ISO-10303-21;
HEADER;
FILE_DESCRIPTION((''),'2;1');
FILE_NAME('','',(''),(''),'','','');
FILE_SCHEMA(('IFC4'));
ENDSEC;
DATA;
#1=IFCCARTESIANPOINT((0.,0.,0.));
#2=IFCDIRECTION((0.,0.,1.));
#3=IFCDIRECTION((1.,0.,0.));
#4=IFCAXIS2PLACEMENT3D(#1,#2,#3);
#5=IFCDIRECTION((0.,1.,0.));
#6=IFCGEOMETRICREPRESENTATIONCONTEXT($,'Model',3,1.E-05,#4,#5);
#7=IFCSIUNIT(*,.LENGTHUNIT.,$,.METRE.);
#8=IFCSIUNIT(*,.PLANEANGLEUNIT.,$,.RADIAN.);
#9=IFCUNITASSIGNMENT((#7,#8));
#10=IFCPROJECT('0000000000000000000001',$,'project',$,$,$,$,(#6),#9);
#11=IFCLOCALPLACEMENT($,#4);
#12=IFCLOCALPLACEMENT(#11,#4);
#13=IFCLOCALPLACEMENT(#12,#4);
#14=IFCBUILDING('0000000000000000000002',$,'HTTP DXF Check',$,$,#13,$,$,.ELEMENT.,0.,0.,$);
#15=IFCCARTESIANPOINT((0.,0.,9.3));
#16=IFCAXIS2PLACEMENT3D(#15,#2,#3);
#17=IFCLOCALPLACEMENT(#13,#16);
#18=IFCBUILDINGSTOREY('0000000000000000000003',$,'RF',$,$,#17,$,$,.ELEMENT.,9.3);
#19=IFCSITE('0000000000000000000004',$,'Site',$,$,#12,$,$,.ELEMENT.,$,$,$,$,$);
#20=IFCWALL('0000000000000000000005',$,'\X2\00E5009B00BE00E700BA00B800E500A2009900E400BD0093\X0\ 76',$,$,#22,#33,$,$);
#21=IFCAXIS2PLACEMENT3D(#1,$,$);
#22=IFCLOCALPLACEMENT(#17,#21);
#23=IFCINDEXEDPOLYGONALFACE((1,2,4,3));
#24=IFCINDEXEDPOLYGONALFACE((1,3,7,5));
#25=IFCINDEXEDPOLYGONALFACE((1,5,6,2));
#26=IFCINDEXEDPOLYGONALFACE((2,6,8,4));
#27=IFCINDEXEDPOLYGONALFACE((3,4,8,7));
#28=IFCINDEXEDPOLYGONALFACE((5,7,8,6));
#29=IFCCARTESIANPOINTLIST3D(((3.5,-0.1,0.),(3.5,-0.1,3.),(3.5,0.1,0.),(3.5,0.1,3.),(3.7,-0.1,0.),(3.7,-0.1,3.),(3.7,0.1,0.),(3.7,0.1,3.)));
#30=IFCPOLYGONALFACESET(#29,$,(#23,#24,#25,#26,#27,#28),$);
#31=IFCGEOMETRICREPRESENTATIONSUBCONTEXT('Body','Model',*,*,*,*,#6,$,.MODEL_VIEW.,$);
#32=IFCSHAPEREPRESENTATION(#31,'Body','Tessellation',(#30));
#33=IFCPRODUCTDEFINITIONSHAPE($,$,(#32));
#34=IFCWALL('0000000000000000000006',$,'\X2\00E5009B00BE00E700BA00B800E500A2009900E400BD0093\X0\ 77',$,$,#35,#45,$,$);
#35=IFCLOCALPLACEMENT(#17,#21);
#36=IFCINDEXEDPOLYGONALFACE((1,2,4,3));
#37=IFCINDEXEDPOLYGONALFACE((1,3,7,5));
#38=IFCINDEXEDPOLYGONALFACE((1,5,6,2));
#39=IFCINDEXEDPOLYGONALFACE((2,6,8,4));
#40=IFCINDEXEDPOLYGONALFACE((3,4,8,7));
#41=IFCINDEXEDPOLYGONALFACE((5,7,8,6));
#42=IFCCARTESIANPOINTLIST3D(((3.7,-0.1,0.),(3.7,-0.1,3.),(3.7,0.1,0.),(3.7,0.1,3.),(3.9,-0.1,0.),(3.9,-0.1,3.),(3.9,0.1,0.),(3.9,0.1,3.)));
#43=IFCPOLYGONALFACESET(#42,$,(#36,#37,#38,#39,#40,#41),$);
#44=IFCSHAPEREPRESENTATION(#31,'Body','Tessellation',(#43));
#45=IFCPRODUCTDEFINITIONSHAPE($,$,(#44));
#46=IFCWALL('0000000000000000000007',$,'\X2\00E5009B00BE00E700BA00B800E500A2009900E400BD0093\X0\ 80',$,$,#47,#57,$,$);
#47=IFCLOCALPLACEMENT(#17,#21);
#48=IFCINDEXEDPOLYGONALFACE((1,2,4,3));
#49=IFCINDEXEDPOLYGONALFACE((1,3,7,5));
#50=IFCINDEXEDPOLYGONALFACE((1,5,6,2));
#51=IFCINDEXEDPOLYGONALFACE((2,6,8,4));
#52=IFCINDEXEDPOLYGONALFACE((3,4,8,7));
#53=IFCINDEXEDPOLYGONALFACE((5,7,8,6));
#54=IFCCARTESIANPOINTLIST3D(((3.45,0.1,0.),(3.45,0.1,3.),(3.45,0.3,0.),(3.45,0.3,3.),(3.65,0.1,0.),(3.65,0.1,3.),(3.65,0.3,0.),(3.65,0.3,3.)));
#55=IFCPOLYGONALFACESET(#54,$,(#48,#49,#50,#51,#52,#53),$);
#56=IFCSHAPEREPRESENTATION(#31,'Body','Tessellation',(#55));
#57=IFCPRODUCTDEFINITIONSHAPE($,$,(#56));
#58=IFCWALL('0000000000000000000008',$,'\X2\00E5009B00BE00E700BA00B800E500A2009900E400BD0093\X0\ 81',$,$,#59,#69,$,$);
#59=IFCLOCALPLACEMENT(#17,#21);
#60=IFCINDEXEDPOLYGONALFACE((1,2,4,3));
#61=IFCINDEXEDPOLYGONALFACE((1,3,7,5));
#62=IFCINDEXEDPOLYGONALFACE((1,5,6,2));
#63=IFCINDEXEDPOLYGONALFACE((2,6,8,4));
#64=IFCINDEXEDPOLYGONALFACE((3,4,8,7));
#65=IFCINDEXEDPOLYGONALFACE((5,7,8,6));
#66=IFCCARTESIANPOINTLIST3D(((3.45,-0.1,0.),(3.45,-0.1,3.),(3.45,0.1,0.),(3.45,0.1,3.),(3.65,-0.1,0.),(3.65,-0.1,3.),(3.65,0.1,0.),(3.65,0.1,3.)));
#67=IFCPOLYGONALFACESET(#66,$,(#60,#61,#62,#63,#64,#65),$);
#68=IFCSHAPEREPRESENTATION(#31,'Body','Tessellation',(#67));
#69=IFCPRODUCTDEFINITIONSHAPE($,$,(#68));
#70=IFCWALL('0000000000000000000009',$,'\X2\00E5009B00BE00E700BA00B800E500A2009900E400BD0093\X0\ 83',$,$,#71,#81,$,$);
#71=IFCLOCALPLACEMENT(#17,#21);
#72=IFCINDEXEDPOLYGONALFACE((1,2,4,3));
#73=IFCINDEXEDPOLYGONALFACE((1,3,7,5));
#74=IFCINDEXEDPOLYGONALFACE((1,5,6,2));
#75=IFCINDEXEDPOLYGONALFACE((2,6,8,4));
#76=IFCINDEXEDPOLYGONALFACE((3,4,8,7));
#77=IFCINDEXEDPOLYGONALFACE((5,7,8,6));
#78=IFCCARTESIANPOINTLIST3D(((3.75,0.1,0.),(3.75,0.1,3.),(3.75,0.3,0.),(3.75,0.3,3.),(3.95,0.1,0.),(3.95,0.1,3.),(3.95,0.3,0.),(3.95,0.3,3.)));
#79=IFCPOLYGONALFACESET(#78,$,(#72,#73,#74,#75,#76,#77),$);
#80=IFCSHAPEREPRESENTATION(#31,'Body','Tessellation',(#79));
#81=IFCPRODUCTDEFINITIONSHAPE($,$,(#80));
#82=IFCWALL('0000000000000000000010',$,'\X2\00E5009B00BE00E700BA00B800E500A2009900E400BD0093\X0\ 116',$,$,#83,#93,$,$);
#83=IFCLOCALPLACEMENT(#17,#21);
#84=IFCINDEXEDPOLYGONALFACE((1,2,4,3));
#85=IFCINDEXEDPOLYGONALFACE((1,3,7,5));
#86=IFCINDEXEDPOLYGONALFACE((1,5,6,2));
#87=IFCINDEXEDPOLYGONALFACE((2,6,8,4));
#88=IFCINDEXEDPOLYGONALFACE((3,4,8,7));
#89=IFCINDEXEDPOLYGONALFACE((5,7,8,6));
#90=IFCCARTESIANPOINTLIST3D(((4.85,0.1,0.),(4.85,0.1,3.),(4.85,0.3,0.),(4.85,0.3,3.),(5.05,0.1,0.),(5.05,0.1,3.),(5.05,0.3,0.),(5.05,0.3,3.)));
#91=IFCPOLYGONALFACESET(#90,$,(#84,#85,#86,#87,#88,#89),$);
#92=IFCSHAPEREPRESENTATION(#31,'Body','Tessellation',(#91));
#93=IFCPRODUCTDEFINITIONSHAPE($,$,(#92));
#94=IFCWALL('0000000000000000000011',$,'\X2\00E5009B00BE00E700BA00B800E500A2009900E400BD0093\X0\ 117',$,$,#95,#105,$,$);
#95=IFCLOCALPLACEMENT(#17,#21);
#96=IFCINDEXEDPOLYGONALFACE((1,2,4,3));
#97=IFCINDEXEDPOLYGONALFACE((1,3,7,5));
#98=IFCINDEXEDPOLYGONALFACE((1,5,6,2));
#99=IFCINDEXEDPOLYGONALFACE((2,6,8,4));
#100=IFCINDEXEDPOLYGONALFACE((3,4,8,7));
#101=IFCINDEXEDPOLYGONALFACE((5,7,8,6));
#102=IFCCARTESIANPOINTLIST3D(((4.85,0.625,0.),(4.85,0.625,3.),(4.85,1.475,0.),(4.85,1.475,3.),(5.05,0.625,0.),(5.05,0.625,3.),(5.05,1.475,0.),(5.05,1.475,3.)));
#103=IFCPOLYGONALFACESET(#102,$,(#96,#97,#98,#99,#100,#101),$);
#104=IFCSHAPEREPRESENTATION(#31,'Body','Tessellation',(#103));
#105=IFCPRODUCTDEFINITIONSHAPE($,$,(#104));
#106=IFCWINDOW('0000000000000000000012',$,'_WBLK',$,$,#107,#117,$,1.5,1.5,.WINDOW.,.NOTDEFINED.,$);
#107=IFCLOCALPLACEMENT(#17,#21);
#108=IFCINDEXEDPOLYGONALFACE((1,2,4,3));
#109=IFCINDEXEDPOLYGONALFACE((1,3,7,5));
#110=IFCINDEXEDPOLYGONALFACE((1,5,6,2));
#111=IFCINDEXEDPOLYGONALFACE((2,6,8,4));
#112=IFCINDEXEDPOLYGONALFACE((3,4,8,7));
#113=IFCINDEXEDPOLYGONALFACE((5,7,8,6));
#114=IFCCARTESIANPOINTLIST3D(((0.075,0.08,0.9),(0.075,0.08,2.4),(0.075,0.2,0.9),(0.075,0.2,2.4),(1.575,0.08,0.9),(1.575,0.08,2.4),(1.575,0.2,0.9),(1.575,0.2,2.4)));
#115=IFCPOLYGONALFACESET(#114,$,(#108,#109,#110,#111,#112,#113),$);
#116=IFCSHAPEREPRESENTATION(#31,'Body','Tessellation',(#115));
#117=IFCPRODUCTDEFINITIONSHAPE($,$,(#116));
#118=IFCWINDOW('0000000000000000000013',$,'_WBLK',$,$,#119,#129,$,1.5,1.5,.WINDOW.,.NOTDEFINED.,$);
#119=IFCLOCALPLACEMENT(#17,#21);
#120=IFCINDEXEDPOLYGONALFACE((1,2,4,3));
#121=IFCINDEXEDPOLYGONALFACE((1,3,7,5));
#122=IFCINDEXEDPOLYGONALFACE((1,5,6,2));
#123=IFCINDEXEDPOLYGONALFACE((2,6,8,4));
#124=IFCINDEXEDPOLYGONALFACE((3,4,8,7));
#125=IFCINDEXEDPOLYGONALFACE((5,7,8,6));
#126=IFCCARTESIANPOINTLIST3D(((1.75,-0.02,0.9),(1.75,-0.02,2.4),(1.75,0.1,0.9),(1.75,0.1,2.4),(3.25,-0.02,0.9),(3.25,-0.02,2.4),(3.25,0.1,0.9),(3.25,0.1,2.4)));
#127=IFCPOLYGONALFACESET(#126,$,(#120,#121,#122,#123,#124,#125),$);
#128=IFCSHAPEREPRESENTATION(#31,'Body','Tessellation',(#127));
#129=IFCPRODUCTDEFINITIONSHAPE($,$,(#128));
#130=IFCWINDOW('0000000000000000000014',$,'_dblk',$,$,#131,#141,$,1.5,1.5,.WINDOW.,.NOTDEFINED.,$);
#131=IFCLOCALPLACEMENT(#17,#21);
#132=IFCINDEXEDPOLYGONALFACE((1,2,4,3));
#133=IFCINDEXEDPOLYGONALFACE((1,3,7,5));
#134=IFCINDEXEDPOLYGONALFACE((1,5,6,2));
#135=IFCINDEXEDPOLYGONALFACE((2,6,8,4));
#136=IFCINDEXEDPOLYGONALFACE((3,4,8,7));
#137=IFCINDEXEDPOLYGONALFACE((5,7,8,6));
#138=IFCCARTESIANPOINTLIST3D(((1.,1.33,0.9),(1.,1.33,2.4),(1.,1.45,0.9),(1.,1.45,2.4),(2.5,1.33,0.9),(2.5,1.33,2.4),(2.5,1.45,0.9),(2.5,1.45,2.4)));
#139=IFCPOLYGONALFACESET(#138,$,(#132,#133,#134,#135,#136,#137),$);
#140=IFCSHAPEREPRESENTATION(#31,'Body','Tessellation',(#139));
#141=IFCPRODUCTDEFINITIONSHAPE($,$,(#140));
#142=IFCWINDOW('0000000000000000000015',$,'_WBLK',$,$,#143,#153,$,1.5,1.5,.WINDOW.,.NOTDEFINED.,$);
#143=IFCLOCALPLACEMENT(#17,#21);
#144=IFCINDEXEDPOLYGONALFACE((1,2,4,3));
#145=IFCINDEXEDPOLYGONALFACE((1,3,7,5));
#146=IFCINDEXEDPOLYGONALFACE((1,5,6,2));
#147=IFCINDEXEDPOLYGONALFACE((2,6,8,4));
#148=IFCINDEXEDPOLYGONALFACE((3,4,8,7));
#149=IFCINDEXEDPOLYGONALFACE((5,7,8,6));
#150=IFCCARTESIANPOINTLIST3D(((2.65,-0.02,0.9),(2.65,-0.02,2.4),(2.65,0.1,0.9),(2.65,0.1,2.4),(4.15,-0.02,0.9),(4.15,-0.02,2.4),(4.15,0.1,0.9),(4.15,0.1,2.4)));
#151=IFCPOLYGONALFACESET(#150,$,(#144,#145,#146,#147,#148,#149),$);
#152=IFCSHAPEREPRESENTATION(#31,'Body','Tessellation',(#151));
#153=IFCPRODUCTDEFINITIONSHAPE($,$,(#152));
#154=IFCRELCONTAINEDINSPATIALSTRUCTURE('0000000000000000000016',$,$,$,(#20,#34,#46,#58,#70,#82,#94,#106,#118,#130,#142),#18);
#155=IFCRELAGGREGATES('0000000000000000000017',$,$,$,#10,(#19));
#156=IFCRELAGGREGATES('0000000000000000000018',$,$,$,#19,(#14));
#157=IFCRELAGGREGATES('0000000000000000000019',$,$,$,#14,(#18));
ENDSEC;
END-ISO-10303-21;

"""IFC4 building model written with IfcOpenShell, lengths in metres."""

from ifc_helpers import new_model, si_unit, direction, frame, frame_2d, origin_with_axes, place, context, subcontext, project, spatial, rectangle, extrude, element, save


model = new_model("IFC4")

# Units and contexts
model_context = context("Model", 3, precision=1e-05, world=origin_with_axes(), true_north=direction((0.0, 1.0, 0.0)))
body_context = subcontext(model_context, "Body", "Model", "MODEL_VIEW")
ifc_project = project(units=[si_unit("LENGTHUNIT", "METRE"), si_unit("PLANEANGLEUNIT", "RADIAN")], contexts=[model_context])

# Site, building, storey
placement = place(None, origin_with_axes())
site_placement = place(placement, origin_with_axes())
site = spatial("IfcSite", under=ifc_project, at=site_placement, Name="Site", CompositionType="ELEMENT")
building_placement = place(site_placement, origin_with_axes())
building = spatial("IfcBuilding", under=site, at=building_placement, Name="HTTP DXF Check", CompositionType="ELEMENT", ElevationOfRefHeight=0.0, ElevationOfTerrain=0.0)
storey_placement = place(building_placement, frame((0.0, 0.0, 9.3), z_axis=(0.0, 0.0, 1.0), x_axis=(1.0, 0.0, 0.0)))
storey = spatial("IfcBuildingStorey", under=building, at=storey_placement, Name="RF", CompositionType="ELEMENT", Elevation=9.3)

# Walls
for number, where, z_axis, x_axis, name in (
    (1, (3.6, 0.0, 0.0), (0.0, 0.0, 1.0), (1.0, 0.0, 0.0), "å\u009b¾çº¸å¢\u0099ä½\u0093 76"),
    (2, (3.8, 0.0, 0.0), (0.0, 0.0, 1.0), (1.0, 0.0, 0.0), "å\u009b¾çº¸å¢\u0099ä½\u0093 77"),
    (3, (3.55, 0.2, 0.0), (0.0, 0.0, 1.0), (1.0, 0.0, 0.0), "å\u009b¾çº¸å¢\u0099ä½\u0093 80"),
    (4, (3.55, 0.0, 0.0), (0.0, 0.0, 1.0), (1.0, 0.0, 0.0), "å\u009b¾çº¸å¢\u0099ä½\u0093 81"),
    (5, (3.85, 0.2, 0.0), (0.0, 0.0, 1.0), (-1.0, 0.0, 0.0), "å\u009b¾çº¸å¢\u0099ä½\u0093 83"),
    (6, (4.95, 0.2, 0.0), (0.0, 0.0, 1.0), (0.0, -1.0, 0.0), "å\u009b¾çº¸å¢\u0099ä½\u0093 116"),
):
    element("IfcWall", number, at=place(storey_placement, frame(where, z_axis=z_axis, x_axis=x_axis)), inside=storey, Name=name, context=body_context, shape_type="SweptSolid", body=[
        extrude(rectangle(XDim=0.2, YDim=0.2, at=frame_2d((0.0, 0.0), x_axis=(1.0, 0.0, 0.0))), frame((0.0, 0.0, 0.0), z_axis=(0.0, 0.0, 1.0)), (0.0, 0.0, 1.0), 3.0),
    ])
wall_1_placement = place(storey_placement, frame((4.95, 1.05, 0.0), z_axis=(0.0, 0.0, 1.0), x_axis=(0.0, -1.0, 0.0)))
element("IfcWall", 7, at=wall_1_placement, inside=storey, Name="å\u009b¾çº¸å¢\u0099ä½\u0093 117", context=body_context, shape_type="SweptSolid", body=[
    extrude(rectangle(XDim=0.85, YDim=0.2, at=frame_2d((0.0, 0.0), x_axis=(1.0, 0.0, 0.0))), frame((0.0, 0.0, 0.0), z_axis=(0.0, 0.0, 1.0)), (0.0, 0.0, 1.0), 3.0),
])

# Windows
for number, where, z_axis, x_axis, name in (
    (8, (0.825, 0.14, 0.9), (0.0, 0.0, 1.0), (1.0, 0.0, 0.0), "_WBLK"),
    (9, (2.5, 0.04, 0.9), (0.0, 0.0, 1.0), (1.0, 0.0, 0.0), "_WBLK"),
    (10, (1.75, 1.39, 0.9), (0.0, 0.0, 1.0), (1.0, 0.0, 0.0), "_dblk"),
    (11, (3.4, 0.04, 0.9), (0.0, 0.0, 1.0), (1.0, 0.0, 0.0), "_WBLK"),
):
    element("IfcWindow", number, at=place(storey_placement, frame(where, z_axis=z_axis, x_axis=x_axis)), inside=storey, Name=name, OverallHeight=1.5, OverallWidth=1.5, PartitioningType="NOTDEFINED", PredefinedType="WINDOW", context=body_context, shape_type="SweptSolid", body=[
        extrude(rectangle(XDim=1.5, YDim=0.12, at=frame_2d((0.0, 0.0), x_axis=(1.0, 0.0, 0.0))), frame((0.0, 0.0, 0.0), z_axis=(0.0, 0.0, 1.0)), (0.0, 0.0, 1.0), 1.5),
    ])

save(model, "model.ifc")
